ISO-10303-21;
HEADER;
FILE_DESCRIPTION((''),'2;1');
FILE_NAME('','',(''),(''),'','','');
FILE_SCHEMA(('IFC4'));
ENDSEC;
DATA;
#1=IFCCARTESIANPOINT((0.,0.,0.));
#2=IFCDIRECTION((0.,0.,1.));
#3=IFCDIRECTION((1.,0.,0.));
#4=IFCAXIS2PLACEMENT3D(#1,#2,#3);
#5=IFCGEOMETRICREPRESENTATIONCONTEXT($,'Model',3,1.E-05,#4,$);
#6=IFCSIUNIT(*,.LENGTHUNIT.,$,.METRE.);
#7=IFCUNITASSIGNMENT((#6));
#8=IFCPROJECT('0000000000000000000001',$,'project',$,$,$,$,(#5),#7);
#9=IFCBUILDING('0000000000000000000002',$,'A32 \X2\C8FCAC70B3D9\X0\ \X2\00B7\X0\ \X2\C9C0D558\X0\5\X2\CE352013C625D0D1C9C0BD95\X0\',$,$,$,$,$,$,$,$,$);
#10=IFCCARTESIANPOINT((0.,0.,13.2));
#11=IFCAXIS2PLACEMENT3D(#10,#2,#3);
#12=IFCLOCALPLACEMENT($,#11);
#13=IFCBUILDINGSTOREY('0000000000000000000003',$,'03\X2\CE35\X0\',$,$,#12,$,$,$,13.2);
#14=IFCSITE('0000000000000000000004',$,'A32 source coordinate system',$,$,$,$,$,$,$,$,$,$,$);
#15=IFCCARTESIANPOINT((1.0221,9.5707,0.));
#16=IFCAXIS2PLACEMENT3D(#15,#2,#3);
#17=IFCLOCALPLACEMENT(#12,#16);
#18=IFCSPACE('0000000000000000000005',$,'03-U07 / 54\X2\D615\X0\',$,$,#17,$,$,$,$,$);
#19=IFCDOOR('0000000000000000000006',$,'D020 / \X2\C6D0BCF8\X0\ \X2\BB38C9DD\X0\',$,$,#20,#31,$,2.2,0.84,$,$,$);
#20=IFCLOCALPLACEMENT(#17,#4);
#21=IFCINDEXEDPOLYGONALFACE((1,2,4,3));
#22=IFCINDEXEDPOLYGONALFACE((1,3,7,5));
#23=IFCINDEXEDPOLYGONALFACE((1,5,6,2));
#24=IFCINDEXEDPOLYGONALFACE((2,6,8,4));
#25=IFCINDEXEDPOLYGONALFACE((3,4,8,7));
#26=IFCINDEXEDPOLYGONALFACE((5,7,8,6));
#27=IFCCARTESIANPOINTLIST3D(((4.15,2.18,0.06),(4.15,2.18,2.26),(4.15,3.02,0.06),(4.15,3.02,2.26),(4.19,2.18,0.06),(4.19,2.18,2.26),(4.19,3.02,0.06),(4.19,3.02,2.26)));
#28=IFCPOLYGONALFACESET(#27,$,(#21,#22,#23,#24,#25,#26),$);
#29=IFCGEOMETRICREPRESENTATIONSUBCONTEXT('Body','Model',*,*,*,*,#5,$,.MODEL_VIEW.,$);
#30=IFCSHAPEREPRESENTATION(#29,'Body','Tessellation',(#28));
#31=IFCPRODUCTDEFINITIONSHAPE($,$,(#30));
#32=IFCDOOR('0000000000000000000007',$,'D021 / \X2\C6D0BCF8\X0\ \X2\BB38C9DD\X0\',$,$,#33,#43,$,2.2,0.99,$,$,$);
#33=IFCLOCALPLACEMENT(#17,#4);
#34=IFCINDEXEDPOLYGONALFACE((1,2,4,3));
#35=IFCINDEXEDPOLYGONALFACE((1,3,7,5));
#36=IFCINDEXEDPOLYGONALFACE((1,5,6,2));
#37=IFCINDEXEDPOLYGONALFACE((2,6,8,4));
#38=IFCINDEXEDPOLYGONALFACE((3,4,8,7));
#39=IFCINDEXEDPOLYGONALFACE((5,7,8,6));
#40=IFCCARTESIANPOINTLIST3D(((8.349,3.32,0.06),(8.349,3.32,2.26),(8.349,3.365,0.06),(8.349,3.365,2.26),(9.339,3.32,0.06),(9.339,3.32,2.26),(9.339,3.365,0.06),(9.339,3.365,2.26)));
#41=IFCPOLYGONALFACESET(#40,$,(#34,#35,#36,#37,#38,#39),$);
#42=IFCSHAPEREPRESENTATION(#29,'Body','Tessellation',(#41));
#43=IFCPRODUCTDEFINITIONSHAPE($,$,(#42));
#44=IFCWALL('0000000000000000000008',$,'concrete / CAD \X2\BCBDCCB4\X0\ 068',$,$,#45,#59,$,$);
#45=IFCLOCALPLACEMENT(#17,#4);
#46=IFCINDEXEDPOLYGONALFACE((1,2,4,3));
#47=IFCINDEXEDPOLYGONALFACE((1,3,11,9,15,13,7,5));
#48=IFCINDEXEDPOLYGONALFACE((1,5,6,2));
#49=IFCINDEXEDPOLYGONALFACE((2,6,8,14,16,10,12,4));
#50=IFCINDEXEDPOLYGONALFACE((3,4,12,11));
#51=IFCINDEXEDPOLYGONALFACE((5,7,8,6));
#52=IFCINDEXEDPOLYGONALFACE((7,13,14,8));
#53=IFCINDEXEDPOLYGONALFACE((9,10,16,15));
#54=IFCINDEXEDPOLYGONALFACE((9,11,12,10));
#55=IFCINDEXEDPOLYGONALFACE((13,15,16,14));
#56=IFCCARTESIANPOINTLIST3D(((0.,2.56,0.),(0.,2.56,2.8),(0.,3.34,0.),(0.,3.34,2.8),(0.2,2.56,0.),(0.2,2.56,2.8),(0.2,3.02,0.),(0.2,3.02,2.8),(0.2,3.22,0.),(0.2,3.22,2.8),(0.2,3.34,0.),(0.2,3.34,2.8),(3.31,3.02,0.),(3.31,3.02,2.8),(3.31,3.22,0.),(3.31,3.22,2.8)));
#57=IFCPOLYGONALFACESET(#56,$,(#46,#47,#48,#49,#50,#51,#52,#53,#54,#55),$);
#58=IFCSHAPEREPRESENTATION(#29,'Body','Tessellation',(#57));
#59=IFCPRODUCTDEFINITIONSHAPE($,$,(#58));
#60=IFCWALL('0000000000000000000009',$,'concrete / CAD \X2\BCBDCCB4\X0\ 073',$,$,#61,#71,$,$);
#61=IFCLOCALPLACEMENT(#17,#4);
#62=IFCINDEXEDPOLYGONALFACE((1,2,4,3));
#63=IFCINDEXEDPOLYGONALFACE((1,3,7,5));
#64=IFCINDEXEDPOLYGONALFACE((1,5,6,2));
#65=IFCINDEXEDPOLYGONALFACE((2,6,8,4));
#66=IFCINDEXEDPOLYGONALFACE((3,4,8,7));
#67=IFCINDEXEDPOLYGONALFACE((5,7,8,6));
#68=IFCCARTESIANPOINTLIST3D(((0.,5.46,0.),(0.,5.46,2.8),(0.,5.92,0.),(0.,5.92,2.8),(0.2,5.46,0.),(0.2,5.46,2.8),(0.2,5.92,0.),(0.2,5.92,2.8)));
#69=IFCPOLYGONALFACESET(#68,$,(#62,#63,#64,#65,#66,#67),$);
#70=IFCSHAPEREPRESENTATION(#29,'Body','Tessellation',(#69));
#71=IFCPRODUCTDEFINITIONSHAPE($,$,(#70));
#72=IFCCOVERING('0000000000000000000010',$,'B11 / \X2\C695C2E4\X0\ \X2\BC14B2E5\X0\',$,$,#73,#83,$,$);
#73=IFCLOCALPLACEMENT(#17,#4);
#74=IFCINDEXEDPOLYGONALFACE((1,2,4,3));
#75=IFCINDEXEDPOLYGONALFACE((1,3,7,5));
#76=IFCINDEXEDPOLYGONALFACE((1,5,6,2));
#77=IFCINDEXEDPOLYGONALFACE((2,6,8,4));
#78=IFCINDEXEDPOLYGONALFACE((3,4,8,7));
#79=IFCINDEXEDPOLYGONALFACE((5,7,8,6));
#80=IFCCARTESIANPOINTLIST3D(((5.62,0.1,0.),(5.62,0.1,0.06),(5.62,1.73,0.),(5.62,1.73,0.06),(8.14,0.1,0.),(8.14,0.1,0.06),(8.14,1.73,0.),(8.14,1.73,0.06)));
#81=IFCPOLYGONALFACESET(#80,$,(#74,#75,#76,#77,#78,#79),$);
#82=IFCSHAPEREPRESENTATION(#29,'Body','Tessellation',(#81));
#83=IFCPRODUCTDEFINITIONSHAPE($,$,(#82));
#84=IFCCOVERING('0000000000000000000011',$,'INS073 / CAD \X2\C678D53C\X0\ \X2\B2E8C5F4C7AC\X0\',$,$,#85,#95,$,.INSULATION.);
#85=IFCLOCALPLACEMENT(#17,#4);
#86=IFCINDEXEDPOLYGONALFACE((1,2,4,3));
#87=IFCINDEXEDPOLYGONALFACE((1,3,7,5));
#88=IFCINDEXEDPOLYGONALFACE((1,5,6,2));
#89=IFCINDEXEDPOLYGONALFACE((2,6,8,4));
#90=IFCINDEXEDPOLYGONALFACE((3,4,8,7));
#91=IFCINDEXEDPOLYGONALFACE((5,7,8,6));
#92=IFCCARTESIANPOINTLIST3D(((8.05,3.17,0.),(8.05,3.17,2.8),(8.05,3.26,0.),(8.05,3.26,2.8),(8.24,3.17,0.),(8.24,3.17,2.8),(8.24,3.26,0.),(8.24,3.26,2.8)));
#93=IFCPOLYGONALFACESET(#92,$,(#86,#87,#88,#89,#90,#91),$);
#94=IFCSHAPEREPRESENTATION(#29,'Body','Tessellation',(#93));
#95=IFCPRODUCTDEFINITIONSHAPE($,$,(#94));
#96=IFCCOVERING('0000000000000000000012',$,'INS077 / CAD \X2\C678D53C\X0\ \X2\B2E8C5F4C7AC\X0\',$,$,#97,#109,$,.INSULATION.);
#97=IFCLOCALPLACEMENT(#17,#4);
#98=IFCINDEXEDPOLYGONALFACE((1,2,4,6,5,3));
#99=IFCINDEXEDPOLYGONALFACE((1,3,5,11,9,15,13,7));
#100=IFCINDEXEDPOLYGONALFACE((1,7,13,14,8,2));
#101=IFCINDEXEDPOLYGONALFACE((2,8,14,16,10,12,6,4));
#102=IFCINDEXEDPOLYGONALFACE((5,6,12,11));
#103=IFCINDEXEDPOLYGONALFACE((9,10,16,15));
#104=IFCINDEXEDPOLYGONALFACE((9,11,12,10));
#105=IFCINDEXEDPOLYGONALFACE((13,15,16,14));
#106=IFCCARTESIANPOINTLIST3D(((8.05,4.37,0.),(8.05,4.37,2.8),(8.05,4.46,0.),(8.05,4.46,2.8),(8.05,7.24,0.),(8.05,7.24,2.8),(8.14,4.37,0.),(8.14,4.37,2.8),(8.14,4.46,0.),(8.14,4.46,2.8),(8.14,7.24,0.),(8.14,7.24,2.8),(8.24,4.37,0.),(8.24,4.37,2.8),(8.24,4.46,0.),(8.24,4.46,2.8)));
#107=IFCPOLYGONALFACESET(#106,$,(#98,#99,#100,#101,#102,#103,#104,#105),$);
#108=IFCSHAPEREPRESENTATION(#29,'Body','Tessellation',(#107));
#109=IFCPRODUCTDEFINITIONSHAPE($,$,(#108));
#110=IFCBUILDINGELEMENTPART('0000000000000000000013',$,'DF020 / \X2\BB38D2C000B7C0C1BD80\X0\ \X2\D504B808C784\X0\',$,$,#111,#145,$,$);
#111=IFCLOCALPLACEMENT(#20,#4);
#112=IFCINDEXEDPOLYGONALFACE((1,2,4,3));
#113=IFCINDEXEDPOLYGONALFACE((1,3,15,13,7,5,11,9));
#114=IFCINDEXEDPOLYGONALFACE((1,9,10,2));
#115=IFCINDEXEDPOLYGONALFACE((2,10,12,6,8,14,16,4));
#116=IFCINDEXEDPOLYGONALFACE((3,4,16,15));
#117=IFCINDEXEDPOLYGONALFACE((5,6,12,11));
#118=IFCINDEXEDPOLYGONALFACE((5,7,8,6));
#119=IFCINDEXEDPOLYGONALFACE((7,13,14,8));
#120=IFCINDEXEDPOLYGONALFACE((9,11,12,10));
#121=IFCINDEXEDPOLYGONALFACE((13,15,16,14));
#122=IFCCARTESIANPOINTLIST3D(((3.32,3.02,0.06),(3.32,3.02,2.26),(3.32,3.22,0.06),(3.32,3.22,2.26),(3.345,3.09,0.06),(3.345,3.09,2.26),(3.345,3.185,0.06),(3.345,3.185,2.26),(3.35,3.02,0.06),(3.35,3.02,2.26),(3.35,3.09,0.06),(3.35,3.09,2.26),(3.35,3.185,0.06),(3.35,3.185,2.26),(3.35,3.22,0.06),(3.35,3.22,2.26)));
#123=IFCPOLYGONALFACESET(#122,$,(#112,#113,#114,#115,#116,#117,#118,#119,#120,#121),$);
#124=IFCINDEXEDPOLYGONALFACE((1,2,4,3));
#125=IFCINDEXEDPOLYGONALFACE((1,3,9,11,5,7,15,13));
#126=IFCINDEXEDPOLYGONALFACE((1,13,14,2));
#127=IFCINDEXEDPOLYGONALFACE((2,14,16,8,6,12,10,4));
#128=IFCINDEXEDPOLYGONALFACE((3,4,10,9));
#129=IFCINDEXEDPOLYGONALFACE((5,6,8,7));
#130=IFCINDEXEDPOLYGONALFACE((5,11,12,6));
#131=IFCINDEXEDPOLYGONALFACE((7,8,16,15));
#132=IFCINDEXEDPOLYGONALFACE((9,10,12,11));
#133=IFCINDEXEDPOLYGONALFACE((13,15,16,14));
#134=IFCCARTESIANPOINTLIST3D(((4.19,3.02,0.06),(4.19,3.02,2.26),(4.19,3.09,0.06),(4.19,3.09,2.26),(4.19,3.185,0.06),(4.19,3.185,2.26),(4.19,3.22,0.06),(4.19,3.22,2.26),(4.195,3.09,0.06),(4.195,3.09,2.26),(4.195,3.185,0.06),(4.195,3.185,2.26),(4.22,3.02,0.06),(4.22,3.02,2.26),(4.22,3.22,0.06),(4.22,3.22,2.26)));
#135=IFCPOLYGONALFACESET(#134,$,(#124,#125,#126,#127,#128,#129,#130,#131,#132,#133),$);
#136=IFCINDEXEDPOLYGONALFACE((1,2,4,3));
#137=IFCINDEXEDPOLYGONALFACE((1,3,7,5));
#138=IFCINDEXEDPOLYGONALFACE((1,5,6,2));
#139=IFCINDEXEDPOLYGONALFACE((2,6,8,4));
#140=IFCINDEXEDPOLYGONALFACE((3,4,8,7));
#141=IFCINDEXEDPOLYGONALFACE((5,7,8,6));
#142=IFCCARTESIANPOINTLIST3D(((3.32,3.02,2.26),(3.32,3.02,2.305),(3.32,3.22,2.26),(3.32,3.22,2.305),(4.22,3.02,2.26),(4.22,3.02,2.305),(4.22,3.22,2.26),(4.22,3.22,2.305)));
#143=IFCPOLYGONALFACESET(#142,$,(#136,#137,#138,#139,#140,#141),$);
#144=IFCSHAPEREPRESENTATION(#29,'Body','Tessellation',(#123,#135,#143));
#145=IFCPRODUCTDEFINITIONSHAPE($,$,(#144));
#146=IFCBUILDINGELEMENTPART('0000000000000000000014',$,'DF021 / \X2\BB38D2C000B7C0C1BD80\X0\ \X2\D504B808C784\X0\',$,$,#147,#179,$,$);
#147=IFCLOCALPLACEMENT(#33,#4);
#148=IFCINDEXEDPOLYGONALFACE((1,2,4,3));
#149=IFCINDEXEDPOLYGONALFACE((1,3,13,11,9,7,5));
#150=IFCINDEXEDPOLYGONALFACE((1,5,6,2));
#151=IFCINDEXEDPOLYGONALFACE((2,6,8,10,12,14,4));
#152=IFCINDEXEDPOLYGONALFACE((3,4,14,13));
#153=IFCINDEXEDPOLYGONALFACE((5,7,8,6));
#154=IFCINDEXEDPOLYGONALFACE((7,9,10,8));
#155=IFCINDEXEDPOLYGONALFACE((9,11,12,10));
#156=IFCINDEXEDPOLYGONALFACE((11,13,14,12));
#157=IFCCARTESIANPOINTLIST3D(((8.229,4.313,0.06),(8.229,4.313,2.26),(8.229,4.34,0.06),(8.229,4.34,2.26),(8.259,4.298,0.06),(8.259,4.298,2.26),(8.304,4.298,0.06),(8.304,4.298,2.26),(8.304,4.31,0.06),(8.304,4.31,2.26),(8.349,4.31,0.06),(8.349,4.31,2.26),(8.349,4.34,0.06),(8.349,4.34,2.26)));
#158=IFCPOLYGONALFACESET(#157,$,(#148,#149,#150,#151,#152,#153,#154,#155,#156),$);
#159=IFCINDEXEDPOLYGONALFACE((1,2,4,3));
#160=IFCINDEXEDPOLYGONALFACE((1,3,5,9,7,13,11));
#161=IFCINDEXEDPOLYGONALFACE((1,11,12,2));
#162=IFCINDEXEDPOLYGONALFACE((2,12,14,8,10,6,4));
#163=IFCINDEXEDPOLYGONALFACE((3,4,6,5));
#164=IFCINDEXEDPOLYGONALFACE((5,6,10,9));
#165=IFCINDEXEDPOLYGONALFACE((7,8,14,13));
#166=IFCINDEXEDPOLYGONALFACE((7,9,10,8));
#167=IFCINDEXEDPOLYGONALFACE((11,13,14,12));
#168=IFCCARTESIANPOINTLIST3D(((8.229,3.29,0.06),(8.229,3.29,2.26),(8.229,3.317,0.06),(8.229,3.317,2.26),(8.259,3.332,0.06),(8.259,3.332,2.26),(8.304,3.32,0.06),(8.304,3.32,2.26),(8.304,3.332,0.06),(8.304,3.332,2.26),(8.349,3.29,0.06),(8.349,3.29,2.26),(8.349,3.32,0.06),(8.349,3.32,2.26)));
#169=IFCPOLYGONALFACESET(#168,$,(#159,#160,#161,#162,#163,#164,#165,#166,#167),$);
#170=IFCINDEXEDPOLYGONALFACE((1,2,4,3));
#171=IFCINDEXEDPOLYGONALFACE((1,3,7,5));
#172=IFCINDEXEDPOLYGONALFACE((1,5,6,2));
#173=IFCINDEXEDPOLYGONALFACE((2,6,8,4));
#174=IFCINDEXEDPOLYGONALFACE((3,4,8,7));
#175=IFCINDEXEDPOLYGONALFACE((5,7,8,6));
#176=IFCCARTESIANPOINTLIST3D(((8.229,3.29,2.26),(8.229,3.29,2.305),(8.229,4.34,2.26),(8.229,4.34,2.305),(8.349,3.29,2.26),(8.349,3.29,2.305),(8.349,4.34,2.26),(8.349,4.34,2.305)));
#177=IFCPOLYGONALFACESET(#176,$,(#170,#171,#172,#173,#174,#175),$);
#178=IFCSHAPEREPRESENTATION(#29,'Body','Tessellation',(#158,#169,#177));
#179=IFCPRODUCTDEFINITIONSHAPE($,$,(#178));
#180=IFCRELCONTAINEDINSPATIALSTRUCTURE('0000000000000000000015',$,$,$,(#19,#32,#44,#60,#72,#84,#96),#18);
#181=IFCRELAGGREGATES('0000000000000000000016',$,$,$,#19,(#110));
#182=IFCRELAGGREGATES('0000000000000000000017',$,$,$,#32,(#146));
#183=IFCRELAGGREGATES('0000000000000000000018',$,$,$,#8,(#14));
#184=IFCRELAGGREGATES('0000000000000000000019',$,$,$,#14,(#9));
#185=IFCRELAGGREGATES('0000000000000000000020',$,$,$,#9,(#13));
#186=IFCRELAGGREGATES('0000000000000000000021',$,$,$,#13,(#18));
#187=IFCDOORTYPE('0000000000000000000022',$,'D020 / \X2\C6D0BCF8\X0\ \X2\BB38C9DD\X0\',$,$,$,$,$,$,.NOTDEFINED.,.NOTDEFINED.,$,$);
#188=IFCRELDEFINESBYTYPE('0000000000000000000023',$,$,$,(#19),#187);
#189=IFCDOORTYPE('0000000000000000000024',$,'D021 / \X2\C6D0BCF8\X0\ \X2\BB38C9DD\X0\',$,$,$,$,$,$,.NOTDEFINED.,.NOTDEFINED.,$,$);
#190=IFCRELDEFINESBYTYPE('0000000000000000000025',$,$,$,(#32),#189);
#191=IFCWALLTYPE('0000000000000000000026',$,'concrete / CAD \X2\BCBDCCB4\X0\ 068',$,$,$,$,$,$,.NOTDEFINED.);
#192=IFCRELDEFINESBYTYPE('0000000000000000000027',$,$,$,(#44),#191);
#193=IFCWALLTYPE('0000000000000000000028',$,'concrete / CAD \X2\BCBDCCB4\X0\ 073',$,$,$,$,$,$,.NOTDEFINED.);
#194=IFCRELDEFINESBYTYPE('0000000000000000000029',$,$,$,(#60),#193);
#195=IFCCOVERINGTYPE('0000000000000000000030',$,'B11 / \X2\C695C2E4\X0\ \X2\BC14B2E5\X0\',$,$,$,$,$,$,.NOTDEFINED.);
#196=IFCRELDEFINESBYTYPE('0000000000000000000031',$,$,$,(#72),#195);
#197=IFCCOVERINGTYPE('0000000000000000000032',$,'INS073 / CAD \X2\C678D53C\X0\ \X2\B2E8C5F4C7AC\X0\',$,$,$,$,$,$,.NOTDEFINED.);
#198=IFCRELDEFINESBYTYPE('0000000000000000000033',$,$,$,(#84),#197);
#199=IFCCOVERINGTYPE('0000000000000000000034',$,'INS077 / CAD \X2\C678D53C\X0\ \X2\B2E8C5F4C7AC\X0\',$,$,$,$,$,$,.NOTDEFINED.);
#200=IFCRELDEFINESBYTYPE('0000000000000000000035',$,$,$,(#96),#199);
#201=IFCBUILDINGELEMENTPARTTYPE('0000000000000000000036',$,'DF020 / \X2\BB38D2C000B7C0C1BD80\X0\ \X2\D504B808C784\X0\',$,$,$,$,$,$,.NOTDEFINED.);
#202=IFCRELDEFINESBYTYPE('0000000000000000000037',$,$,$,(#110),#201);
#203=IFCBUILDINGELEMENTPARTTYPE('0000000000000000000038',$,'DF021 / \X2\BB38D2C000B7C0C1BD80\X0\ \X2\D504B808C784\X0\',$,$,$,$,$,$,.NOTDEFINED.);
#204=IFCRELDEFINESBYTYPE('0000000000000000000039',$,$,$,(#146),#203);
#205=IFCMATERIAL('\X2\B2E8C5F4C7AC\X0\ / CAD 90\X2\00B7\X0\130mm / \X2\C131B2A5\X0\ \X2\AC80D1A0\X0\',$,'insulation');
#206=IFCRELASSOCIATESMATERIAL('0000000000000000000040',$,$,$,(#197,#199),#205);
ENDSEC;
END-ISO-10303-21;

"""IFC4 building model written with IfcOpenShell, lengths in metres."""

from ifc_helpers import new_model, si_unit, frame, origin, origin_with_axes, place, context, subcontext, project, spatial, polyline, outline, extrude, source, transform, mapped, material, type_object, type_shapes, element, aggregate, save


model = new_model("IFC4")

# Units and contexts
model_context = context("Model", 3, precision=1e-05, world=origin_with_axes())
body_context = subcontext(model_context, "Body", "Model", "MODEL_VIEW")
ifc_project = project(units=[si_unit("LENGTHUNIT", "METRE")], contexts=[model_context])

# Site, building, storey, space
storey_placement = place(None, frame((0.0, 0.0, 13.2), z_axis=(0.0, 0.0, 1.0), x_axis=(1.0, 0.0, 0.0)))
space_placement = place(storey_placement, frame((1.0221, 9.5707, 0.0), z_axis=(0.0, 0.0, 1.0), x_axis=(1.0, 0.0, 0.0)))
site = spatial("IfcSite", under=ifc_project, Name="A32 source coordinate system")
building = spatial("IfcBuilding", under=site, Name="A32 주거동 · 지하5층–옥탑지붕")
storey = spatial("IfcBuildingStorey", under=building, at=storey_placement, Name="03층", Elevation=13.2)
space = spatial("IfcSpace", under=storey, at=space_placement, Name="03-U07 / 54형")

# Doors
door_type_1 = type_object("IfcDoorType", Name="D020 / 원본 문짝", OperationType="NOTDEFINED", PredefinedType="NOTDEFINED")
shared_shape_1 = source(origin(), body_context, "Body", "SweptSolid", [
    extrude(outline(polyline([(4.19, 3.02), (4.19, 2.18), (4.15, 2.18), (4.15, 3.02), (4.19, 3.02)])), frame((0.0, 0.0, 0.06)), (0.0, 0.0, 1.0), 2.2),
])
type_shapes(door_type_1, [shared_shape_1])
door_1_placement = place(space_placement, origin_with_axes())
door_1 = element("IfcDoor", 1, at=door_1_placement, inside=space, type_object=door_type_1, Name="D020 / 원본 문짝", OverallHeight=2.2, OverallWidth=0.84, context=body_context, shape_type="MappedRepresentation", body=[
    mapped(shared_shape_1, transform((0.0, 0.0, 0.0), scale=1.0)),
])
door_type_2 = type_object("IfcDoorType", Name="D021 / 원본 문짝", OperationType="NOTDEFINED", PredefinedType="NOTDEFINED")
shared_shape_2 = source(origin(), body_context, "Body", "SweptSolid", [
    extrude(outline(polyline([(9.339, 3.365), (9.339, 3.32), (8.349, 3.32), (8.349, 3.365), (9.339, 3.365)])), frame((0.0, 0.0, 0.06)), (0.0, 0.0, 1.0), 2.2),
])
type_shapes(door_type_2, [shared_shape_2])
door_2_placement = place(space_placement, origin_with_axes())
door_2 = element("IfcDoor", 2, at=door_2_placement, inside=space, type_object=door_type_2, Name="D021 / 원본 문짝", OverallHeight=2.2, OverallWidth=0.99, context=body_context, shape_type="MappedRepresentation", body=[
    mapped(shared_shape_2, transform((0.0, 0.0, 0.0), scale=1.0)),
])

# Walls
wall_type_1 = type_object("IfcWallType", Name="concrete / CAD 벽체 068", PredefinedType="NOTDEFINED")
shared_shape_3 = source(origin(), body_context, "Body", "SweptSolid", [
    extrude(outline(polyline([(0.2, 3.02), (0.2, 2.56), (0.0, 2.56), (0.0, 3.34), (0.2, 3.34), (0.2, 3.22), (3.31, 3.22), (3.31, 3.02), (0.2, 3.02)])), origin(), (0.0, 0.0, 1.0), 2.8),
])
type_shapes(wall_type_1, [shared_shape_3])
wall_1_placement = place(space_placement, origin_with_axes())
element("IfcWall", 3, at=wall_1_placement, inside=space, type_object=wall_type_1, Name="concrete / CAD 벽체 068", context=body_context, shape_type="MappedRepresentation", body=[
    mapped(shared_shape_3, transform((0.0, 0.0, 0.0), scale=1.0)),
])
wall_type_2 = type_object("IfcWallType", Name="concrete / CAD 벽체 073", PredefinedType="NOTDEFINED")
shared_shape_4 = source(origin(), body_context, "Body", "SweptSolid", [
    extrude(outline(polyline([(0.2, 5.92), (0.2, 5.46), (0.0, 5.46), (0.0, 5.92), (0.2, 5.92)])), origin(), (0.0, 0.0, 1.0), 2.8),
])
type_shapes(wall_type_2, [shared_shape_4])
wall_2_placement = place(space_placement, origin_with_axes())
element("IfcWall", 4, at=wall_2_placement, inside=space, type_object=wall_type_2, Name="concrete / CAD 벽체 073", context=body_context, shape_type="MappedRepresentation", body=[
    mapped(shared_shape_4, transform((0.0, 0.0, 0.0), scale=1.0)),
])

# Coverings
covering_type_1 = type_object("IfcCoveringType", Name="B11 / 욕실 바닥", PredefinedType="NOTDEFINED")
shared_shape_5 = source(origin(), body_context, "Body", "SweptSolid", [
    extrude(outline(polyline([(8.14, 1.73), (8.14, 0.1), (5.62, 0.1), (5.62, 1.73), (8.14, 1.73)])), origin(), (0.0, 0.0, 1.0), 0.06),
])
type_shapes(covering_type_1, [shared_shape_5])
covering_1_placement = place(space_placement, origin_with_axes())
element("IfcCovering", 5, at=covering_1_placement, inside=space, type_object=covering_type_1, Name="B11 / 욕실 바닥", context=body_context, shape_type="MappedRepresentation", body=[
    mapped(shared_shape_5, transform((0.0, 0.0, 0.0), scale=1.0)),
])
ifc_material = material(Name="단열재 / CAD 90·130mm / 성능 검토", Category="insulation")
covering_type_2 = type_object("IfcCoveringType", Name="INS073 / CAD 외피 단열재", PredefinedType="NOTDEFINED", material=ifc_material)
shared_shape_6 = source(origin(), body_context, "Body", "SweptSolid", [
    extrude(outline(polyline([(8.05, 3.17), (8.05, 3.26), (8.24, 3.26), (8.24, 3.17), (8.05, 3.17)])), origin(), (0.0, 0.0, 1.0), 2.8),
])
type_shapes(covering_type_2, [shared_shape_6])
covering_2_placement = place(space_placement, origin_with_axes())
element("IfcCovering", 6, at=covering_2_placement, inside=space, type_object=covering_type_2, Name="INS073 / CAD 외피 단열재", PredefinedType="INSULATION", context=body_context, shape_type="MappedRepresentation", body=[
    mapped(shared_shape_6, transform((0.0, 0.0, 0.0), scale=1.0)),
])
covering_type_3 = type_object("IfcCoveringType", Name="INS077 / CAD 외피 단열재", PredefinedType="NOTDEFINED", material=ifc_material)
shared_shape_7 = source(origin(), body_context, "Body", "SweptSolid", [
    extrude(outline(polyline([(8.24, 4.37), (8.14, 4.37), (8.05, 4.37), (8.05, 4.46), (8.05, 7.24), (8.14, 7.24), (8.14, 4.46), (8.24, 4.46), (8.24, 4.37)])), origin(), (0.0, 0.0, 1.0), 2.8),
])
type_shapes(covering_type_3, [shared_shape_7])
covering_3_placement = place(space_placement, origin_with_axes())
element("IfcCovering", 7, at=covering_3_placement, inside=space, type_object=covering_type_3, Name="INS077 / CAD 외피 단열재", PredefinedType="INSULATION", context=body_context, shape_type="MappedRepresentation", body=[
    mapped(shared_shape_7, transform((0.0, 0.0, 0.0), scale=1.0)),
])

# Building element parts
building_element_part_type_1 = type_object("IfcBuildingElementPartType", Name="DF020 / 문틀·상부 프레임", PredefinedType="NOTDEFINED")
shared_shape_8 = source(origin(), body_context, "Body", "SweptSolid", [
    extrude(outline(polyline([(3.32, 3.22), (3.35, 3.22), (3.35, 3.185), (3.345, 3.185), (3.345, 3.09), (3.35, 3.09), (3.35, 3.02), (3.32, 3.02), (3.32, 3.22)])), frame((0.0, 0.0, 0.06)), (0.0, 0.0, 1.0), 2.2),
    extrude(outline(polyline([(4.19, 3.02), (4.19, 3.09), (4.195, 3.09), (4.195, 3.185), (4.19, 3.185), (4.19, 3.22), (4.22, 3.22), (4.22, 3.02), (4.19, 3.02)])), frame((0.0, 0.0, 0.06)), (0.0, 0.0, 1.0), 2.2),
    extrude(outline(polyline([(3.32, 3.02), (3.32, 3.22), (4.22, 3.22), (4.22, 3.02), (3.32, 3.02)])), frame((0.0, 0.0, 2.26)), (0.0, 0.0, 1.0), 0.045),
])
type_shapes(building_element_part_type_1, [shared_shape_8])
building_element_part_1_placement = place(door_1_placement, origin_with_axes())
building_element_part_1 = element("IfcBuildingElementPart", 8, at=building_element_part_1_placement, type_object=building_element_part_type_1, Name="DF020 / 문틀·상부 프레임", context=body_context, shape_type="MappedRepresentation", body=[
    mapped(shared_shape_8, transform((0.0, 0.0, 0.0), scale=1.0)),
])
aggregate(door_1, [building_element_part_1])
building_element_part_type_2 = type_object("IfcBuildingElementPartType", Name="DF021 / 문틀·상부 프레임", PredefinedType="NOTDEFINED")
shared_shape_9 = source(origin(), body_context, "Body", "SweptSolid", [
    extrude(outline(polyline([(8.349, 4.31), (8.304, 4.31), (8.304, 4.298), (8.259, 4.298), (8.229, 4.313), (8.229, 4.34), (8.349, 4.34), (8.349, 4.31)])), frame((0.0, 0.0, 0.06)), (0.0, 0.0, 1.0), 2.2),
    extrude(outline(polyline([(8.229, 3.29), (8.229, 3.317), (8.259, 3.332), (8.304, 3.332), (8.304, 3.32), (8.349, 3.32), (8.349, 3.29), (8.229, 3.29)])), frame((0.0, 0.0, 0.06)), (0.0, 0.0, 1.0), 2.2),
    extrude(outline(polyline([(8.229, 3.29), (8.229, 4.34), (8.349, 4.34), (8.349, 3.29), (8.229, 3.29)])), frame((0.0, 0.0, 2.26)), (0.0, 0.0, 1.0), 0.045),
])
type_shapes(building_element_part_type_2, [shared_shape_9])
building_element_part_2_placement = place(door_2_placement, origin_with_axes())
building_element_part_2 = element("IfcBuildingElementPart", 9, at=building_element_part_2_placement, type_object=building_element_part_type_2, Name="DF021 / 문틀·상부 프레임", context=body_context, shape_type="MappedRepresentation", body=[
    mapped(shared_shape_9, transform((0.0, 0.0, 0.0), scale=1.0)),
])
aggregate(door_2, [building_element_part_2])

save(model, "model.ifc")
